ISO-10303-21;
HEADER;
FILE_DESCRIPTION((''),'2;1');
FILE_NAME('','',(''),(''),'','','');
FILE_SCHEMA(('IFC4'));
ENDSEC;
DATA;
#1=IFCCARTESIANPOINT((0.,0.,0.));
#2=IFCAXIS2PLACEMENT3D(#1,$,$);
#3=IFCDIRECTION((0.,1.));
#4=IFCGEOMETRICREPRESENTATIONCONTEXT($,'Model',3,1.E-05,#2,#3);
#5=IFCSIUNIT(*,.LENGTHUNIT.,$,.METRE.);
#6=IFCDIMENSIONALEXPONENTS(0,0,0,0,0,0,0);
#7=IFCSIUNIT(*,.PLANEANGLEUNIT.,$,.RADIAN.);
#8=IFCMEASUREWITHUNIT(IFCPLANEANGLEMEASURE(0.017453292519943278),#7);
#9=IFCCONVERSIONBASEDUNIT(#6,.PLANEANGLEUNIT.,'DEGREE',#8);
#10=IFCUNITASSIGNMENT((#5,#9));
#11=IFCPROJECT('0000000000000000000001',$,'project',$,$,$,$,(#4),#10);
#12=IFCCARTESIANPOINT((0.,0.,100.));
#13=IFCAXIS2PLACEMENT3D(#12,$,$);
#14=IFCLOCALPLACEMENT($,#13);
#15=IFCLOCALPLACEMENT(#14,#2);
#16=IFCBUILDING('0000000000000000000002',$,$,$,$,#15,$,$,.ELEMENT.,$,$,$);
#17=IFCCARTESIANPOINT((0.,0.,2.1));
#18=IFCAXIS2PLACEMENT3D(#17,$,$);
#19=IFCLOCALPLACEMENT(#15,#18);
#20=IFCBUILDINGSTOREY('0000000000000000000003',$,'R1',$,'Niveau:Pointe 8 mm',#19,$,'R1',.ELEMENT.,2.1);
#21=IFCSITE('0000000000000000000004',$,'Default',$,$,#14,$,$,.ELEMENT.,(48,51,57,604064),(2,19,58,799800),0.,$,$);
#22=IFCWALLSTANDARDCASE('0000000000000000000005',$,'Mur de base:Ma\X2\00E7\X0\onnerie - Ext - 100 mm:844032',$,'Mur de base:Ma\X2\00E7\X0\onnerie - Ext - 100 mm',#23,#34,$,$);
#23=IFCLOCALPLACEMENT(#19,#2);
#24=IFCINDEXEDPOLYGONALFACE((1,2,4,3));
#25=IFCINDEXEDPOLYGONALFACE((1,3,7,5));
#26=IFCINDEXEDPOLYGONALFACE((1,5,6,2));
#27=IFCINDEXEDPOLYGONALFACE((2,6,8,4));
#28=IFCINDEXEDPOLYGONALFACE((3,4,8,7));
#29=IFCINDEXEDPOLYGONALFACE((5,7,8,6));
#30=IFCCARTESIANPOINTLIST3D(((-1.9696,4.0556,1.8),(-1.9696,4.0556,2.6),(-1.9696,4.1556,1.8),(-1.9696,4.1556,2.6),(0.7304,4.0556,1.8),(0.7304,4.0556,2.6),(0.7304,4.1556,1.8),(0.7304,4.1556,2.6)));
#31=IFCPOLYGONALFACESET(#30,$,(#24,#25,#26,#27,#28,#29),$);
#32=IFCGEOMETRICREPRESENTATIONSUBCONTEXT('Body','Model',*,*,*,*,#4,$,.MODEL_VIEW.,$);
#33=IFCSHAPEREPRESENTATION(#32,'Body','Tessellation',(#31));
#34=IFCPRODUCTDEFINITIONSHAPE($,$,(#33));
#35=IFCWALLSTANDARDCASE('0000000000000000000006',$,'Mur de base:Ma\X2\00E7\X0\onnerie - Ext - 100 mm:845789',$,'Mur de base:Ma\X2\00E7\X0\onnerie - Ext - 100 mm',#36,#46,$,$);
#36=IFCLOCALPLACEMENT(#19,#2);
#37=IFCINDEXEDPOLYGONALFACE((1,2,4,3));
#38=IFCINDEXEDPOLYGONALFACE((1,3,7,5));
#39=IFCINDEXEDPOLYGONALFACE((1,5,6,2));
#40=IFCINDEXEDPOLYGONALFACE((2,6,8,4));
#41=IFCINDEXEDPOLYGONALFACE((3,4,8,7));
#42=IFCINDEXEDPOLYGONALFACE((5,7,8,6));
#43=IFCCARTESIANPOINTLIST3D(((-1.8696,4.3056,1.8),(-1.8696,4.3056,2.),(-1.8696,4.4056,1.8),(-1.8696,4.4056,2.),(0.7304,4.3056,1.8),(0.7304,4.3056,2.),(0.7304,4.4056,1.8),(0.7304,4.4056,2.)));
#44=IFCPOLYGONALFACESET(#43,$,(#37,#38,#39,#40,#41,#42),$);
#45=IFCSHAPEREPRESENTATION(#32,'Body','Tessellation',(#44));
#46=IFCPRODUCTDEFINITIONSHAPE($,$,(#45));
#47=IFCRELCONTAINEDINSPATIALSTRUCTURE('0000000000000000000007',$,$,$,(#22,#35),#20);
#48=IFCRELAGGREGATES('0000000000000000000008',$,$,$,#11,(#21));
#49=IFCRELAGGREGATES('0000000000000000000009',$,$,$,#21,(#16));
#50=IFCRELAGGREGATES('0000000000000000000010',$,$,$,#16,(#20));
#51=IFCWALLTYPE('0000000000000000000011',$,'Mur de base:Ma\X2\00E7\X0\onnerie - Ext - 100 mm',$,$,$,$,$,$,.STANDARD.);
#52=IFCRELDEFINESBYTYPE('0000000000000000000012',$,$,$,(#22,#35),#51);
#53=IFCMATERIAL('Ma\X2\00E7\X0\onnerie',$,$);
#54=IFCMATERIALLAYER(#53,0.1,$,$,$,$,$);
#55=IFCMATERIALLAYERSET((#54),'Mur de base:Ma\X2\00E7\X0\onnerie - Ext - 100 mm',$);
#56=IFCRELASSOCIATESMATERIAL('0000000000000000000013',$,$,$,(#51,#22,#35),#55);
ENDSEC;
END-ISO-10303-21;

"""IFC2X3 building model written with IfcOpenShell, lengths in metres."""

from ifc_helpers import new_model, entity, si_unit, converted_unit, direction, frame, frame_2d, origin, place, context, subcontext, project, spatial, rectangle, extrude, material, layer, layer_set, layer_usage, type_object, element, save


model = new_model("IFC2X3")

# Units and contexts
model_context = context("Model", 3, precision=1e-05, world=origin(), true_north=direction((0.0, 1.0)))
body_context = subcontext(model_context, "Body", "Model", "MODEL_VIEW")
ifc_project = project(units=[si_unit("LENGTHUNIT", "METRE"), converted_unit("PLANEANGLEUNIT", "DEGREE", entity("IfcPlaneAngleMeasure", 0.017453292519943278), si_unit("PLANEANGLEUNIT", "RADIAN"), dimensions=[0, 0, 0, 0, 0, 0, 0])], contexts=[model_context])

# Site, building, storey
site_placement = place(None, frame((0.0, 0.0, 100.0)))
site = spatial("IfcSite", under=ifc_project, at=site_placement, Name="Default", CompositionType="ELEMENT", RefLatitude=(48, 51, 57, 604064), RefLongitude=(2, 19, 58, 799800), RefElevation=0.0)
building_placement = place(site_placement, origin())
building = spatial("IfcBuilding", under=site, at=building_placement, CompositionType="ELEMENT")
storey_placement = place(building_placement, frame((0.0, 0.0, 2.1)))
storey = spatial("IfcBuildingStorey", under=building, at=storey_placement, Name="R1", ObjectType="Niveau:Pointe 8 mm", LongName="R1", CompositionType="ELEMENT", Elevation=2.1)

# Walls
ifc_material_1 = material(Name="Maçonnerie")
ifc_layer_1 = layer(ifc_material_1, 0.1)
ifc_layer_set_1 = layer_set([ifc_layer_1], Name="Mur de base:Maçonnerie - Ext - 100 mm")
wall_type = type_object("IfcWallType", Name="Mur de base:Maçonnerie - Ext - 100 mm", PredefinedType="STANDARD", material=ifc_layer_set_1)
ifc_layer_usage_1 = layer_usage(ifc_layer_set_1, "AXIS2", "NEGATIVE", 0.05)
wall_1_placement = place(storey_placement, frame((0.7304, 4.1056, 1.8), z_axis=(0.0, 0.0, 1.0), x_axis=(-1.0, 0.0, 0.0)))
element("IfcWallStandardCase", 1, at=wall_1_placement, inside=storey, type_object=wall_type, material=ifc_layer_usage_1, Name="Mur de base:Maçonnerie - Ext - 100 mm:844032", ObjectType="Mur de base:Maçonnerie - Ext - 100 mm", context=body_context, shape_type="SweptSolid", body=[
    extrude(rectangle(XDim=2.7, YDim=0.1, at=frame_2d((1.35, 0.0), x_axis=(-1.0, 0.0))), origin(), (0.0, 0.0, 1.0), 0.8),
])
ifc_layer_usage_2 = layer_usage(ifc_layer_set_1, "AXIS2", "NEGATIVE", 0.05)
wall_2_placement = place(storey_placement, frame((-1.8696, 4.3556, 1.8)))
element("IfcWallStandardCase", 2, at=wall_2_placement, inside=storey, type_object=wall_type, material=ifc_layer_usage_2, Name="Mur de base:Maçonnerie - Ext - 100 mm:845789", ObjectType="Mur de base:Maçonnerie - Ext - 100 mm", context=body_context, shape_type="SweptSolid", body=[
    extrude(rectangle(XDim=2.6, YDim=0.1, at=frame_2d((1.3, 0.0), x_axis=(-1.0, 0.0))), origin(), (0.0, 0.0, 1.0), 0.2),
])

save(model, "model.ifc")
